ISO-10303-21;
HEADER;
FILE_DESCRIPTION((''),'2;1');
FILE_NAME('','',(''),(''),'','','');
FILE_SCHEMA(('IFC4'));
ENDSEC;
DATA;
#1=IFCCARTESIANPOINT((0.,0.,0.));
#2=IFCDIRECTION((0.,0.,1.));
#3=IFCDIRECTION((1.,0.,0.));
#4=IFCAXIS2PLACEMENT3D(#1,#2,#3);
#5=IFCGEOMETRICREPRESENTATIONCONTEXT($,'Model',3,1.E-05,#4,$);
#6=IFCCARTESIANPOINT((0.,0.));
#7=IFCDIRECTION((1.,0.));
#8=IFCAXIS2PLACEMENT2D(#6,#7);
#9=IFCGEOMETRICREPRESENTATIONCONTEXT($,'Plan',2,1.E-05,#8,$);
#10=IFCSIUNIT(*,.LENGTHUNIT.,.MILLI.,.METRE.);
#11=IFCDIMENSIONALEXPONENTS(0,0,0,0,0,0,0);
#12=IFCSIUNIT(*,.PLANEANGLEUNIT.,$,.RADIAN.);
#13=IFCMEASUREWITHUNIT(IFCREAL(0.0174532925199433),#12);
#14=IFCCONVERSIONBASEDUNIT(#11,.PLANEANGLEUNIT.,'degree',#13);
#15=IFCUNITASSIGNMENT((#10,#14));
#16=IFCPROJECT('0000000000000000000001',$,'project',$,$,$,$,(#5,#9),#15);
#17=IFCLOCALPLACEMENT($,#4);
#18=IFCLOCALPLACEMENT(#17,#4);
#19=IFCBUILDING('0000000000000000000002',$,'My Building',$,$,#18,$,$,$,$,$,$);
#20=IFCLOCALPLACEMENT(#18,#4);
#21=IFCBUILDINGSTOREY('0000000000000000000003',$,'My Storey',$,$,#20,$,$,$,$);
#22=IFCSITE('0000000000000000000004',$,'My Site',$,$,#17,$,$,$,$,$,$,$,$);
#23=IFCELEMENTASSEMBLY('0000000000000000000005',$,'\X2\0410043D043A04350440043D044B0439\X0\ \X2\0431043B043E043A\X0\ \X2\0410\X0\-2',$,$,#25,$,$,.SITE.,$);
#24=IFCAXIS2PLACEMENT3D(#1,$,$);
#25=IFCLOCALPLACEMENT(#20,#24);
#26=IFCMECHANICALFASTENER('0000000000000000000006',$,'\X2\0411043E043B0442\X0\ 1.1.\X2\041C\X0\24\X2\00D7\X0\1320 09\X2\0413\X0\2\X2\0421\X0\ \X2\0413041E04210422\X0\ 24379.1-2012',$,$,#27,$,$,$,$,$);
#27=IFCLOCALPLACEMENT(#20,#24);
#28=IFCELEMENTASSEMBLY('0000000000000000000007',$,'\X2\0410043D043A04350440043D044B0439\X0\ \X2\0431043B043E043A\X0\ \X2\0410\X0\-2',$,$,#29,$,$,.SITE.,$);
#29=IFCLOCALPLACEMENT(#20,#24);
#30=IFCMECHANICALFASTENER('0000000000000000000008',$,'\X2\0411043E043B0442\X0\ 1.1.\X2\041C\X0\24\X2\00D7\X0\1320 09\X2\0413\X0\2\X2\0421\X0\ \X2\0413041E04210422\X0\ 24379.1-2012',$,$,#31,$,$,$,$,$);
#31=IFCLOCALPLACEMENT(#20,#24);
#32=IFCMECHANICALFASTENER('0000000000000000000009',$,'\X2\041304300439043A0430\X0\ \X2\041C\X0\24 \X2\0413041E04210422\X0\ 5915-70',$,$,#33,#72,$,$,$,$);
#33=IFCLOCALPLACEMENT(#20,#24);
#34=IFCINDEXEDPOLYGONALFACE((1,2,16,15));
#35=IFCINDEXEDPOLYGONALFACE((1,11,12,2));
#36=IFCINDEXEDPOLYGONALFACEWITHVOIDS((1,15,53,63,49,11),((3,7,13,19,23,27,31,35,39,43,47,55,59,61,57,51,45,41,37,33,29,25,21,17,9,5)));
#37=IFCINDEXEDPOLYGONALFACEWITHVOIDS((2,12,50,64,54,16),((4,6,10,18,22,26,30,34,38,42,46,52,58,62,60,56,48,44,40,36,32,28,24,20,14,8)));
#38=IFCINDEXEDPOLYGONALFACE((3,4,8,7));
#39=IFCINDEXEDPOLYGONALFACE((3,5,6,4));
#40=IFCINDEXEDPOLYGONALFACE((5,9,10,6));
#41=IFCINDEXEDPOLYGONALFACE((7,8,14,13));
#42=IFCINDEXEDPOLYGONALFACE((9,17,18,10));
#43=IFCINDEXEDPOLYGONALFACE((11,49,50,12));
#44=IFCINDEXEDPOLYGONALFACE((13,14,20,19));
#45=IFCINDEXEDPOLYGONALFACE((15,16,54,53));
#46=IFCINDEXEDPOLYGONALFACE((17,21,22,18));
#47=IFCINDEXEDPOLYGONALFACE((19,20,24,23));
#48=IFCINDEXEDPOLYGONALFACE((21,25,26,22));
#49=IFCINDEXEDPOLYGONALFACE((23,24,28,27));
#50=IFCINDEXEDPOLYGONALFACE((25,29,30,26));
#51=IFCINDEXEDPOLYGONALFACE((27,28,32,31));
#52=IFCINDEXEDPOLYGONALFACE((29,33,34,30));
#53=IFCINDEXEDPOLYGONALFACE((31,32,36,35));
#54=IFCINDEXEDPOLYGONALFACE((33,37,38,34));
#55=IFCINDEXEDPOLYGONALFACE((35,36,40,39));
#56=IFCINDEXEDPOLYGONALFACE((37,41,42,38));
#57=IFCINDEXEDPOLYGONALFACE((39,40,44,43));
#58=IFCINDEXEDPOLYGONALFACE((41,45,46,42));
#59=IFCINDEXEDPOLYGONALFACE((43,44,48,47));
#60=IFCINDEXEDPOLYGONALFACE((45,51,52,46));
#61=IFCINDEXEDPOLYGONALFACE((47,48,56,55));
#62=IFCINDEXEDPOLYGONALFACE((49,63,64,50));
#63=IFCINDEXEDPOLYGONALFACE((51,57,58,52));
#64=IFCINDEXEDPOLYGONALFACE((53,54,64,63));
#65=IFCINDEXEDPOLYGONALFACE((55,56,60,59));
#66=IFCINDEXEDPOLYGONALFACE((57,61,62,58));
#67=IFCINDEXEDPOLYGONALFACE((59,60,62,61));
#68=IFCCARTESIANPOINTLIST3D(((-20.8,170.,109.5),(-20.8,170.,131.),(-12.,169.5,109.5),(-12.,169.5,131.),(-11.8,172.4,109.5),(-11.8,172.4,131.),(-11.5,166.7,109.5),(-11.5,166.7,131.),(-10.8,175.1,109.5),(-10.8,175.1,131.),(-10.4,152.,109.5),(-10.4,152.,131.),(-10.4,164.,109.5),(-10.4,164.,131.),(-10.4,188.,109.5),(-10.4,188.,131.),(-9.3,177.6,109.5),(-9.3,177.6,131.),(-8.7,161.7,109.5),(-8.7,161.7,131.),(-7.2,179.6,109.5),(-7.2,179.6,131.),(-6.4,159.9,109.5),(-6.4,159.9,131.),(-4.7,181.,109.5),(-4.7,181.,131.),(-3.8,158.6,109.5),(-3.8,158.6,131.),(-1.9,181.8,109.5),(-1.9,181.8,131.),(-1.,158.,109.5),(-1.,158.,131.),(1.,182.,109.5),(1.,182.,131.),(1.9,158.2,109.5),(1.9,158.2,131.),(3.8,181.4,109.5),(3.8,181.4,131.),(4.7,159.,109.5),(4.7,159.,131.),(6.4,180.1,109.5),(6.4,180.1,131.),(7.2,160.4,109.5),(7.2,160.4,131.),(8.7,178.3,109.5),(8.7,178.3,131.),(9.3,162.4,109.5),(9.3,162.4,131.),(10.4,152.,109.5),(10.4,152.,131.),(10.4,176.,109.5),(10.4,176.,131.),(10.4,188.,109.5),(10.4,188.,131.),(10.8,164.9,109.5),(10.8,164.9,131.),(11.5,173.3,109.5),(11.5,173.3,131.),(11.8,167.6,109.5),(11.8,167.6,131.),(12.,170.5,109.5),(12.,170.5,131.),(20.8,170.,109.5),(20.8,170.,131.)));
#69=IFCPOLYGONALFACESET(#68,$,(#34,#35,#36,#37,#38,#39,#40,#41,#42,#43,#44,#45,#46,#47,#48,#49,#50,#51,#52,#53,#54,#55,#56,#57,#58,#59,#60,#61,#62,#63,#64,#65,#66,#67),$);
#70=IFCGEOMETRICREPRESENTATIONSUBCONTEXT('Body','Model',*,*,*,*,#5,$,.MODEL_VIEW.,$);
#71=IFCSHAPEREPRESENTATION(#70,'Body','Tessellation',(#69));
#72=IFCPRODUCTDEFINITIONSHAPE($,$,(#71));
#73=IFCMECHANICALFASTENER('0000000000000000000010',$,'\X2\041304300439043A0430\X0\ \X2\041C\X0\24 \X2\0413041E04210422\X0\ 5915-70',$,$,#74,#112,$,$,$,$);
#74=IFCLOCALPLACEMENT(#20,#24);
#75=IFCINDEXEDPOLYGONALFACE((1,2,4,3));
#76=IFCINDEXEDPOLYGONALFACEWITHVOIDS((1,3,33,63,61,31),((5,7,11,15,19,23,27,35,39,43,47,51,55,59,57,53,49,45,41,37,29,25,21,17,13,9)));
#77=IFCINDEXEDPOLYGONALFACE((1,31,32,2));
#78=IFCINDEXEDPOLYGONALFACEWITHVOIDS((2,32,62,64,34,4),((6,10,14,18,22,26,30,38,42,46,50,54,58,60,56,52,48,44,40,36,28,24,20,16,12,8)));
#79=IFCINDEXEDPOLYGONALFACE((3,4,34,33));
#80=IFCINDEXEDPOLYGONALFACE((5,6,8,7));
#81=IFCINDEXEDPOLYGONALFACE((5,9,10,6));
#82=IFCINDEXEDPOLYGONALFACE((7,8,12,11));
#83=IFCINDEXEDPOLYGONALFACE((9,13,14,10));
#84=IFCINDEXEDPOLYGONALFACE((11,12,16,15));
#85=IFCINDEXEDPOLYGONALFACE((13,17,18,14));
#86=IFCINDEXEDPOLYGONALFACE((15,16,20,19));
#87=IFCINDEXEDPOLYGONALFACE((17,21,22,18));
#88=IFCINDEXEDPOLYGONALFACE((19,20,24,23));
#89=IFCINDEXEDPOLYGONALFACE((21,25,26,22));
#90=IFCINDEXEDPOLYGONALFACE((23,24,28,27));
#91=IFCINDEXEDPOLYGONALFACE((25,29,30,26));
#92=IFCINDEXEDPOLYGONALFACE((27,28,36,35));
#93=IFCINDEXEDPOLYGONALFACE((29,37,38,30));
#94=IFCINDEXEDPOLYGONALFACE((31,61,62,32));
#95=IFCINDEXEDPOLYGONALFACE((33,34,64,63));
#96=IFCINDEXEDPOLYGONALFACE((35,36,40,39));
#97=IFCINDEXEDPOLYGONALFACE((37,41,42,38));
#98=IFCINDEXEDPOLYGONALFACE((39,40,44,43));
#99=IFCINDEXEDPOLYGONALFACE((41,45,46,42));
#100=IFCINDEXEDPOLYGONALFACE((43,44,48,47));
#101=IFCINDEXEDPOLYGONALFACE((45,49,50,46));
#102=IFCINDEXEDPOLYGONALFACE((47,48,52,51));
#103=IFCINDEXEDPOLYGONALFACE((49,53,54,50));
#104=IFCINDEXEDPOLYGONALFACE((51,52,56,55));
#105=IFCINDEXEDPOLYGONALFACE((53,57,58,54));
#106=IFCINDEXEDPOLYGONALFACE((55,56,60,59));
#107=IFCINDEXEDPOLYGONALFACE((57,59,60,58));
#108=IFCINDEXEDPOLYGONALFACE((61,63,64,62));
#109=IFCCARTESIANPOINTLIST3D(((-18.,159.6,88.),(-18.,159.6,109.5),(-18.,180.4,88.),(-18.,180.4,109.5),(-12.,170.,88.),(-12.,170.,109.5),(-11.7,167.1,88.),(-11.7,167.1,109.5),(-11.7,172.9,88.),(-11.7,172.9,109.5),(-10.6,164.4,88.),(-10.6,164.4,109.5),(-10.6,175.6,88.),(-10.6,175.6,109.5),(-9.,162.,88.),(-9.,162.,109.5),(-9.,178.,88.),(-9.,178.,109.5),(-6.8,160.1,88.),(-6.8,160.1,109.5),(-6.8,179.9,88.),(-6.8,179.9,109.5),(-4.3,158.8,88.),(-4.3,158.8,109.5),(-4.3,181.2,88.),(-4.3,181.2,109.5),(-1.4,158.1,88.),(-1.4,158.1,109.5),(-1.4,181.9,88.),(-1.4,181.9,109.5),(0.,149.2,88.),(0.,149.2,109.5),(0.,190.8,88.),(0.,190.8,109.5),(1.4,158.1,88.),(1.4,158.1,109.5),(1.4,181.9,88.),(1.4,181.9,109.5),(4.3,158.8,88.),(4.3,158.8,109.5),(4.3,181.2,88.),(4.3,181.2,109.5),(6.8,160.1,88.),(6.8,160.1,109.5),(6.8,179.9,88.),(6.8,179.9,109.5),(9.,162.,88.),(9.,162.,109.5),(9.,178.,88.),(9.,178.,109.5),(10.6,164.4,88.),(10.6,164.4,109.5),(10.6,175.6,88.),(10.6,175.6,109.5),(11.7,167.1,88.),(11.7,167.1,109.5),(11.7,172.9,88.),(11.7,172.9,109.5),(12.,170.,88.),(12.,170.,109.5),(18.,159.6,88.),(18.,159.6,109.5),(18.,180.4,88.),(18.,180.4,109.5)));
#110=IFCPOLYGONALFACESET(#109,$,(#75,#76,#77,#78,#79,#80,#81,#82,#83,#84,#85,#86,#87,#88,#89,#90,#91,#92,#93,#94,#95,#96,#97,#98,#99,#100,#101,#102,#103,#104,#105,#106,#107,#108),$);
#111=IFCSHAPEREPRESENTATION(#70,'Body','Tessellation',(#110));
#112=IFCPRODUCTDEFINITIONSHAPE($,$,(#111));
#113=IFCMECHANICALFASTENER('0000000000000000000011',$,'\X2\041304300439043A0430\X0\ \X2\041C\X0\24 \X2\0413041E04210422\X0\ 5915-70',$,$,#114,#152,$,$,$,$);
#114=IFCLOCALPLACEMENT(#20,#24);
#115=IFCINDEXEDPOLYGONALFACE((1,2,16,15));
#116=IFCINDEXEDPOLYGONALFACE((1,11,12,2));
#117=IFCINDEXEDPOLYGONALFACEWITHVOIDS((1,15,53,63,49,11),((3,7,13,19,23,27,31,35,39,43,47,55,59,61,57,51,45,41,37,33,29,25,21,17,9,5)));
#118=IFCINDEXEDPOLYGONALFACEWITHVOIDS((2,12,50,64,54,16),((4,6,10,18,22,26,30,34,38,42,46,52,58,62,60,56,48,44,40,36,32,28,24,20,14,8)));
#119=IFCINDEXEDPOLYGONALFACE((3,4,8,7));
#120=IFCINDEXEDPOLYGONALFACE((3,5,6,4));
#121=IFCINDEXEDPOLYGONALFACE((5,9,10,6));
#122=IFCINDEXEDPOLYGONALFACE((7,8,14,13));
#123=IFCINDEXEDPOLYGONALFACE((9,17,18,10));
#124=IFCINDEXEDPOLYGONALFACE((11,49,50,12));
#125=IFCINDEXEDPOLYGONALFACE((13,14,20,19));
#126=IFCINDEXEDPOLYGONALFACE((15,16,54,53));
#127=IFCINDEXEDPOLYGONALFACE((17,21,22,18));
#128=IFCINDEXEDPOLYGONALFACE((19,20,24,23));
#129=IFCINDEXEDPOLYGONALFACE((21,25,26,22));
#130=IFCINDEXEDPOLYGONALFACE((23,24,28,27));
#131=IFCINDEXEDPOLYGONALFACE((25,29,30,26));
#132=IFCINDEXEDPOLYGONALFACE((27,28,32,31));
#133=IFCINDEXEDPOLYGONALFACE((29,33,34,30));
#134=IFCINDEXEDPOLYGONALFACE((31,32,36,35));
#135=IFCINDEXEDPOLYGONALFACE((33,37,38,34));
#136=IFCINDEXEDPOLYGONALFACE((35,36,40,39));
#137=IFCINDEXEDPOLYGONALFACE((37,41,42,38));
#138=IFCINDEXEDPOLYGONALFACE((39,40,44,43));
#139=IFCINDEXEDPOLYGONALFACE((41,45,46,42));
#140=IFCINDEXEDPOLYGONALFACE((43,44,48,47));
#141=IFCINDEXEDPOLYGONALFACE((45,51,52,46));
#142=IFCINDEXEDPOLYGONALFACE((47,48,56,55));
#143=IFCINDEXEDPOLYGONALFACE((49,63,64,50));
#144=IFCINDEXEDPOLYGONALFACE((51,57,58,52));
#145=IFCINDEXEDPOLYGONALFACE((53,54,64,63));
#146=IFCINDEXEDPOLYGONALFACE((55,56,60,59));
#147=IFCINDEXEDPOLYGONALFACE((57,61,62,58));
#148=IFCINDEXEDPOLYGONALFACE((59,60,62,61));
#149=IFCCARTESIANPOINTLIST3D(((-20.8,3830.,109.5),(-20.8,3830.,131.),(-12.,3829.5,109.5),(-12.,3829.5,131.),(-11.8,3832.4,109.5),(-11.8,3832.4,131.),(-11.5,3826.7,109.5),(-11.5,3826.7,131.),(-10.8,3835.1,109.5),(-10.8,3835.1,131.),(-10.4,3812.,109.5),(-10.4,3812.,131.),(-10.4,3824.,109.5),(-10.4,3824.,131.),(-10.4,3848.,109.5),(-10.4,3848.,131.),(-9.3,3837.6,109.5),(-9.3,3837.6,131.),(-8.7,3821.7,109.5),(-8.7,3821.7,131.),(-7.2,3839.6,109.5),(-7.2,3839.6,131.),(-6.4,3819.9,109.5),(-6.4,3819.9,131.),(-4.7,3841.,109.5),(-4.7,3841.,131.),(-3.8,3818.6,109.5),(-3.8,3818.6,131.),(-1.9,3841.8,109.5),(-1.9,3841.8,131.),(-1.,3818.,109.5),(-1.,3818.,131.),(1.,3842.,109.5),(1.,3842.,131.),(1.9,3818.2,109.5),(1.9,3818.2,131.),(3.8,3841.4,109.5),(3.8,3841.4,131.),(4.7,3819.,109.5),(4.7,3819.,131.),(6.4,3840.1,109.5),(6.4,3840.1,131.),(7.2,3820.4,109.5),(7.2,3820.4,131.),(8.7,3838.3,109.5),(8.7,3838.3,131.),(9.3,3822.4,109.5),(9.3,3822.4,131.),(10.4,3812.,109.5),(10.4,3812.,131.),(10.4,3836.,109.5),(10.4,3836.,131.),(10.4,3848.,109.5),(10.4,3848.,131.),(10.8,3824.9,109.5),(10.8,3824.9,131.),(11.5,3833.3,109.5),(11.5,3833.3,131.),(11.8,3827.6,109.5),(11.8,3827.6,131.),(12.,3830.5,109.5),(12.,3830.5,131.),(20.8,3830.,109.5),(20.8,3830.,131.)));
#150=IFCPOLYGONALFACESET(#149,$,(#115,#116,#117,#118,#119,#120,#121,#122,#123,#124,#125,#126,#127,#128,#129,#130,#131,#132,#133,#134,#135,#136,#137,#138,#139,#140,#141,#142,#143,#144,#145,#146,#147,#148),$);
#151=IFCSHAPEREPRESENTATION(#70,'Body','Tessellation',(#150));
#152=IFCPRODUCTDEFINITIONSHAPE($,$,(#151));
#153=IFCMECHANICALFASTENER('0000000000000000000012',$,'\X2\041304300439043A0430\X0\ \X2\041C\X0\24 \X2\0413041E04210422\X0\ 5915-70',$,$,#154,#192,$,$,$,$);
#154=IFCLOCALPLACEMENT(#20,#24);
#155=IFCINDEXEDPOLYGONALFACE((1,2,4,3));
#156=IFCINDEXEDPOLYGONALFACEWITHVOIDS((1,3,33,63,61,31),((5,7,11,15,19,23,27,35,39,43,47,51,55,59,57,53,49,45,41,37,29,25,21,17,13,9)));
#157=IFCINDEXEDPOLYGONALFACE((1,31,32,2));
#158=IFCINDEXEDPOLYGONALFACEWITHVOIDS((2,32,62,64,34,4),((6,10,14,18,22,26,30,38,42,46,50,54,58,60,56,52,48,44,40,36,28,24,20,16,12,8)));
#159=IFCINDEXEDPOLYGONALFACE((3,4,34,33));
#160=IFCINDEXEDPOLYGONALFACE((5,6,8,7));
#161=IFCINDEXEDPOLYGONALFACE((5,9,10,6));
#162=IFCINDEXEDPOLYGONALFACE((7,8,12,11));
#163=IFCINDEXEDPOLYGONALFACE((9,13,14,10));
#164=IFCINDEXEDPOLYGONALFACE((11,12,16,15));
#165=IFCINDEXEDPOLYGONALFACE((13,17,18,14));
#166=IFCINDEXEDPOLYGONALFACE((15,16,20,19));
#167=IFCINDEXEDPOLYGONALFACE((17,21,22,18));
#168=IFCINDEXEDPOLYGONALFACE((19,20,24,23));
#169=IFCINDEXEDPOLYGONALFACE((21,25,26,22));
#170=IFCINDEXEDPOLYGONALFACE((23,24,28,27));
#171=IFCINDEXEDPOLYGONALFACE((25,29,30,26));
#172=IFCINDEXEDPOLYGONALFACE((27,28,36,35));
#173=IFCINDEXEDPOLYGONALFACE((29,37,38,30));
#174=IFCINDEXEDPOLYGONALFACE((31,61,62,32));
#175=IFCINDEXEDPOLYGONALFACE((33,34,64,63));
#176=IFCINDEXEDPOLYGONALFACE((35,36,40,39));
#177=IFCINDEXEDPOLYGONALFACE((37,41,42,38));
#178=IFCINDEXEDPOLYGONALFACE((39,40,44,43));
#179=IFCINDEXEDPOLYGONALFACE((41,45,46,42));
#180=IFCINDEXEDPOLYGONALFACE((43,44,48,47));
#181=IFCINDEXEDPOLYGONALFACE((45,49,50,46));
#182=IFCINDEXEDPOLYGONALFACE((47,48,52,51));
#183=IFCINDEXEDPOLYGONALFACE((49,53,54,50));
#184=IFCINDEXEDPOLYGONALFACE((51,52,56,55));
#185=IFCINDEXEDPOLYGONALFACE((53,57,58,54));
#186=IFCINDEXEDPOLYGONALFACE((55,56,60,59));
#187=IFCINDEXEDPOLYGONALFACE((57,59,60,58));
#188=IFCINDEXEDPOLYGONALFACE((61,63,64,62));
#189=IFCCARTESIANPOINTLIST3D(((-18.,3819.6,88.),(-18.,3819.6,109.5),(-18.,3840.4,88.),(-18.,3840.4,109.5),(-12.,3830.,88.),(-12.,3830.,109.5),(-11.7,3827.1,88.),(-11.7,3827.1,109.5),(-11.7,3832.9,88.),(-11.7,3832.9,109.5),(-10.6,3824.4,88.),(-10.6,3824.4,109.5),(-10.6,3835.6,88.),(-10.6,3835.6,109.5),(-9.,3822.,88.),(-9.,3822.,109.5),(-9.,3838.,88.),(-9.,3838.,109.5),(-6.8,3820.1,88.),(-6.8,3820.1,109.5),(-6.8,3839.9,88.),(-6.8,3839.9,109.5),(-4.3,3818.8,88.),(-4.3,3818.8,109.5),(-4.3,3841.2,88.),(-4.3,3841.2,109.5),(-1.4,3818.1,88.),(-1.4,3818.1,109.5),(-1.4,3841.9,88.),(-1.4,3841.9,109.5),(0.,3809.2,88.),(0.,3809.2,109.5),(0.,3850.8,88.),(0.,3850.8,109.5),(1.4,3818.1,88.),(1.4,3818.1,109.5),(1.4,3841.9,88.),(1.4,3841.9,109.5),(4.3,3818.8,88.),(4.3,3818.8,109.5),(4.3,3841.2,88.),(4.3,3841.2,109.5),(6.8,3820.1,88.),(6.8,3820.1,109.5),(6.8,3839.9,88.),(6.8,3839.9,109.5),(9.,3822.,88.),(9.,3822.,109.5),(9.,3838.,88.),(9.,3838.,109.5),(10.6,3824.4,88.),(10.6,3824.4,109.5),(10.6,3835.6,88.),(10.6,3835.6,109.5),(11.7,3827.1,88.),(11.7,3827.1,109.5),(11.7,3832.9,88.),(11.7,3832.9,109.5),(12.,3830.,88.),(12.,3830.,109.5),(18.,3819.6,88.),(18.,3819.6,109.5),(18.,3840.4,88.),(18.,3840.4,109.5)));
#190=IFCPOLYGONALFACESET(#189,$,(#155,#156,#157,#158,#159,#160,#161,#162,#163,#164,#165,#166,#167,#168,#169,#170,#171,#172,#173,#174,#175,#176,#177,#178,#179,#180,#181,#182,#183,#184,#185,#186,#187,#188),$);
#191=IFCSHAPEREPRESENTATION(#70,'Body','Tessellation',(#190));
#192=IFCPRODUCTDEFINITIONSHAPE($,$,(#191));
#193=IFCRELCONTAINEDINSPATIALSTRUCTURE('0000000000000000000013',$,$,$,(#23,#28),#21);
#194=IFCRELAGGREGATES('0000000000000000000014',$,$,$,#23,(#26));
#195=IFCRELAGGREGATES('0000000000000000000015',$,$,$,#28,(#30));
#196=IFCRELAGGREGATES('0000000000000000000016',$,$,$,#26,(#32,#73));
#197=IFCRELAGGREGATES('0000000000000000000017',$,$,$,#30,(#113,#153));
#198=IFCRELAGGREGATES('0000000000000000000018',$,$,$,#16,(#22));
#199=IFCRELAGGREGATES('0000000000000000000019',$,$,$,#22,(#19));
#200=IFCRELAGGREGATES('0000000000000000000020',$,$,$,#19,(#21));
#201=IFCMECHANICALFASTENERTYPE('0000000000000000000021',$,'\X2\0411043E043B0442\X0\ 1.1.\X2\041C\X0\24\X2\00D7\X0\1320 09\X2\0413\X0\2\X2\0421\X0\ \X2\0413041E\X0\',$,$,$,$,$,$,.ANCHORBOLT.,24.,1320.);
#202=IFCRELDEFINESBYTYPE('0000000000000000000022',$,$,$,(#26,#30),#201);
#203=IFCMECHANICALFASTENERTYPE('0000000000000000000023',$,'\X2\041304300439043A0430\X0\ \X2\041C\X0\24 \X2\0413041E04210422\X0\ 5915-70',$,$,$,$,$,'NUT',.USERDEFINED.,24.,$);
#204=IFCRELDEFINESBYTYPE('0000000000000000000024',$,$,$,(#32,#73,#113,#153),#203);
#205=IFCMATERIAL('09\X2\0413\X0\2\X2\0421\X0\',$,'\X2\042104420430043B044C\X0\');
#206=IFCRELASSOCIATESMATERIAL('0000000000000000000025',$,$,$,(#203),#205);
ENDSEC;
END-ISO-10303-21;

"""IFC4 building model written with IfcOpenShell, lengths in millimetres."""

from ifc_helpers import new_model, entity, si_unit, converted_unit, frame, origin_with_axes, origin_2d_with_axis, place, context, subcontext, project, spatial, polyline, outline, extrude, source, transform, mapped, material, type_object, type_shapes, element, aggregate, save


model = new_model("IFC4")

# Units and contexts
model_context = context("Model", 3, precision=1e-05, world=origin_with_axes())
plan_context = context("Plan", 2, precision=1e-05, world=origin_2d_with_axis())
body_context = subcontext(model_context, "Body", "Model", "MODEL_VIEW")
ifc_project = project(units=[si_unit("LENGTHUNIT", "METRE", prefix="MILLI"), converted_unit("PLANEANGLEUNIT", "degree", entity("IfcReal", 0.0174532925199433), si_unit("PLANEANGLEUNIT", "RADIAN"), dimensions=[0, 0, 0, 0, 0, 0, 0])], contexts=[model_context, plan_context])

# Site, building, storey
site_placement = place(None, origin_with_axes())
site = spatial("IfcSite", under=ifc_project, at=site_placement, Name="My Site")
building_placement = place(site_placement, origin_with_axes())
building = spatial("IfcBuilding", under=site, at=building_placement, Name="My Building")
storey_placement = place(building_placement, origin_with_axes())
storey = spatial("IfcBuildingStorey", under=building, at=storey_placement, Name="My Storey")

# Shared definitions
placement_1 = place(storey_placement, origin_with_axes())
placement_2 = place(storey_placement, frame((0.0, 4000.0, 0.0), z_axis=(0.0, 0.0, 1.0), x_axis=(1.0, 0.0, 0.0)))

# Element assemblies, mechanical fasteners
assembly_1 = element("IfcElementAssembly", 1, at=placement_1, inside=storey, Name="Анкерный блок А-2", AssemblyPlace="SITE")
ifc_material_1 = material(Name="09Г2С", Category="Сталь")
mechanical_fastener_type_1 = type_object("IfcMechanicalFastenerType", Name="Болт 1.1.М24×1320 09Г2С ГО", NominalDiameter=24.0, NominalLength=1320.0, PredefinedType="ANCHORBOLT")
mechanical_fastener_1_placement = place(placement_1, frame((0.0, 170.0, 0.0), z_axis=(0.0, 0.0, 1.0), x_axis=(-1.0, 0.0, 0.0)))
mechanical_fastener_1 = element("IfcMechanicalFastener", 2, at=mechanical_fastener_1_placement, type_object=mechanical_fastener_type_1, Name="Болт 1.1.М24×1320 09Г2С ГОСТ 24379.1-2012")
aggregate(assembly_1, [mechanical_fastener_1])
assembly_2 = element("IfcElementAssembly", 3, at=placement_2, inside=storey, Name="Анкерный блок А-2", AssemblyPlace="SITE")
mechanical_fastener_2_placement = place(placement_2, frame((0.0, -170.0, 0.0), z_axis=(0.0, 0.0, 1.0), x_axis=(1.0, 0.0, 0.0)))
mechanical_fastener_2 = element("IfcMechanicalFastener", 4, at=mechanical_fastener_2_placement, type_object=mechanical_fastener_type_1, Name="Болт 1.1.М24×1320 09Г2С ГОСТ 24379.1-2012")
aggregate(assembly_2, [mechanical_fastener_2])

# Mechanical fasteners
mechanical_fastener_type_2 = type_object("IfcMechanicalFastenerType", Name="Гайка М24 ГОСТ 5915-70", ElementType="NUT", NominalDiameter=24.0, PredefinedType="USERDEFINED", material=ifc_material_1)
shared_shape_1 = source(origin_with_axes(), body_context, "Body", "SweptSolid", [
    extrude(outline(polyline([(-10.4, -18.0), (10.4, -18.0), (20.8, 0.0), (10.4, 18.0), (-10.4, 18.0), (-20.8, 0.0), (-10.4, -18.0)]), holes=[polyline([(-8.0, 9.0), (-5.6, 10.6), (-2.9, 11.7), (0.0, 12.0), (2.9, 11.7), (5.6, 10.6), (8.0, 9.0), (9.9, 6.8), (11.2, 4.3), (11.9, 1.4), (11.9, -1.4), (11.2, -4.3), (9.9, -6.8), (8.0, -9.0), (5.6, -10.6), (2.9, -11.7), (0.0, -12.0), (-2.9, -11.7), (-5.6, -10.6), (-8.0, -9.0), (-9.9, -6.8), (-11.2, -4.3), (-11.9, -1.4), (-11.9, 1.4), (-11.2, 4.3), (-9.9, 6.8), (-8.0, 9.0)])]), frame((0.0, 0.0, 0.0), z_axis=(0.0, 0.0, 1.0), x_axis=(0.0, 1.0, 0.0)), (0.0, 0.0, 1.0), 21.5),
])
type_shapes(mechanical_fastener_type_2, [shared_shape_1])
mechanical_fastener_3_placement = place(mechanical_fastener_1_placement, frame((0.0, 0.0, 109.5), z_axis=(0.0, 0.0, 1.0), x_axis=(0.866025, 0.5, 0.0)))
mechanical_fastener_3 = element("IfcMechanicalFastener", 5, at=mechanical_fastener_3_placement, type_object=mechanical_fastener_type_2, Name="Гайка М24 ГОСТ 5915-70", context=body_context, shape_type="MappedRepresentation", body=[
    mapped(shared_shape_1, transform((0.0, 0.0, 0.0), x_axis=(1.0, 0.0, 0.0), y_axis=(0.0, 1.0, 0.0), z_axis=(0.0, 0.0, 1.0), scale=1.0)),
])
mechanical_fastener_4_placement = place(mechanical_fastener_1_placement, frame((0.0, 0.0, 88.0), z_axis=(0.0, 0.0, 1.0), x_axis=(1.0, 0.0, 0.0)))
mechanical_fastener_4 = element("IfcMechanicalFastener", 6, at=mechanical_fastener_4_placement, type_object=mechanical_fastener_type_2, Name="Гайка М24 ГОСТ 5915-70", context=body_context, shape_type="MappedRepresentation", body=[
    mapped(shared_shape_1, transform((0.0, 0.0, 0.0), x_axis=(1.0, 0.0, 0.0), y_axis=(0.0, 1.0, 0.0), z_axis=(0.0, 0.0, 1.0), scale=1.0)),
])
mechanical_fastener_5_placement = place(mechanical_fastener_2_placement, frame((0.0, 0.0, 109.5), z_axis=(0.0, 0.0, 1.0), x_axis=(0.866025, 0.5, 0.0)))
mechanical_fastener_5 = element("IfcMechanicalFastener", 7, at=mechanical_fastener_5_placement, type_object=mechanical_fastener_type_2, Name="Гайка М24 ГОСТ 5915-70", context=body_context, shape_type="MappedRepresentation", body=[
    mapped(shared_shape_1, transform((0.0, 0.0, 0.0), x_axis=(1.0, 0.0, 0.0), y_axis=(0.0, 1.0, 0.0), z_axis=(0.0, 0.0, 1.0), scale=1.0)),
])
mechanical_fastener_6_placement = place(mechanical_fastener_2_placement, frame((0.0, 0.0, 88.0), z_axis=(0.0, 0.0, 1.0), x_axis=(1.0, 0.0, 0.0)))
mechanical_fastener_6 = element("IfcMechanicalFastener", 8, at=mechanical_fastener_6_placement, type_object=mechanical_fastener_type_2, Name="Гайка М24 ГОСТ 5915-70", context=body_context, shape_type="MappedRepresentation", body=[
    mapped(shared_shape_1, transform((0.0, 0.0, 0.0), x_axis=(1.0, 0.0, 0.0), y_axis=(0.0, 1.0, 0.0), z_axis=(0.0, 0.0, 1.0), scale=1.0)),
])
aggregate(mechanical_fastener_1, [mechanical_fastener_3, mechanical_fastener_4])
aggregate(mechanical_fastener_2, [mechanical_fastener_5, mechanical_fastener_6])

save(model, "model.ifc")
